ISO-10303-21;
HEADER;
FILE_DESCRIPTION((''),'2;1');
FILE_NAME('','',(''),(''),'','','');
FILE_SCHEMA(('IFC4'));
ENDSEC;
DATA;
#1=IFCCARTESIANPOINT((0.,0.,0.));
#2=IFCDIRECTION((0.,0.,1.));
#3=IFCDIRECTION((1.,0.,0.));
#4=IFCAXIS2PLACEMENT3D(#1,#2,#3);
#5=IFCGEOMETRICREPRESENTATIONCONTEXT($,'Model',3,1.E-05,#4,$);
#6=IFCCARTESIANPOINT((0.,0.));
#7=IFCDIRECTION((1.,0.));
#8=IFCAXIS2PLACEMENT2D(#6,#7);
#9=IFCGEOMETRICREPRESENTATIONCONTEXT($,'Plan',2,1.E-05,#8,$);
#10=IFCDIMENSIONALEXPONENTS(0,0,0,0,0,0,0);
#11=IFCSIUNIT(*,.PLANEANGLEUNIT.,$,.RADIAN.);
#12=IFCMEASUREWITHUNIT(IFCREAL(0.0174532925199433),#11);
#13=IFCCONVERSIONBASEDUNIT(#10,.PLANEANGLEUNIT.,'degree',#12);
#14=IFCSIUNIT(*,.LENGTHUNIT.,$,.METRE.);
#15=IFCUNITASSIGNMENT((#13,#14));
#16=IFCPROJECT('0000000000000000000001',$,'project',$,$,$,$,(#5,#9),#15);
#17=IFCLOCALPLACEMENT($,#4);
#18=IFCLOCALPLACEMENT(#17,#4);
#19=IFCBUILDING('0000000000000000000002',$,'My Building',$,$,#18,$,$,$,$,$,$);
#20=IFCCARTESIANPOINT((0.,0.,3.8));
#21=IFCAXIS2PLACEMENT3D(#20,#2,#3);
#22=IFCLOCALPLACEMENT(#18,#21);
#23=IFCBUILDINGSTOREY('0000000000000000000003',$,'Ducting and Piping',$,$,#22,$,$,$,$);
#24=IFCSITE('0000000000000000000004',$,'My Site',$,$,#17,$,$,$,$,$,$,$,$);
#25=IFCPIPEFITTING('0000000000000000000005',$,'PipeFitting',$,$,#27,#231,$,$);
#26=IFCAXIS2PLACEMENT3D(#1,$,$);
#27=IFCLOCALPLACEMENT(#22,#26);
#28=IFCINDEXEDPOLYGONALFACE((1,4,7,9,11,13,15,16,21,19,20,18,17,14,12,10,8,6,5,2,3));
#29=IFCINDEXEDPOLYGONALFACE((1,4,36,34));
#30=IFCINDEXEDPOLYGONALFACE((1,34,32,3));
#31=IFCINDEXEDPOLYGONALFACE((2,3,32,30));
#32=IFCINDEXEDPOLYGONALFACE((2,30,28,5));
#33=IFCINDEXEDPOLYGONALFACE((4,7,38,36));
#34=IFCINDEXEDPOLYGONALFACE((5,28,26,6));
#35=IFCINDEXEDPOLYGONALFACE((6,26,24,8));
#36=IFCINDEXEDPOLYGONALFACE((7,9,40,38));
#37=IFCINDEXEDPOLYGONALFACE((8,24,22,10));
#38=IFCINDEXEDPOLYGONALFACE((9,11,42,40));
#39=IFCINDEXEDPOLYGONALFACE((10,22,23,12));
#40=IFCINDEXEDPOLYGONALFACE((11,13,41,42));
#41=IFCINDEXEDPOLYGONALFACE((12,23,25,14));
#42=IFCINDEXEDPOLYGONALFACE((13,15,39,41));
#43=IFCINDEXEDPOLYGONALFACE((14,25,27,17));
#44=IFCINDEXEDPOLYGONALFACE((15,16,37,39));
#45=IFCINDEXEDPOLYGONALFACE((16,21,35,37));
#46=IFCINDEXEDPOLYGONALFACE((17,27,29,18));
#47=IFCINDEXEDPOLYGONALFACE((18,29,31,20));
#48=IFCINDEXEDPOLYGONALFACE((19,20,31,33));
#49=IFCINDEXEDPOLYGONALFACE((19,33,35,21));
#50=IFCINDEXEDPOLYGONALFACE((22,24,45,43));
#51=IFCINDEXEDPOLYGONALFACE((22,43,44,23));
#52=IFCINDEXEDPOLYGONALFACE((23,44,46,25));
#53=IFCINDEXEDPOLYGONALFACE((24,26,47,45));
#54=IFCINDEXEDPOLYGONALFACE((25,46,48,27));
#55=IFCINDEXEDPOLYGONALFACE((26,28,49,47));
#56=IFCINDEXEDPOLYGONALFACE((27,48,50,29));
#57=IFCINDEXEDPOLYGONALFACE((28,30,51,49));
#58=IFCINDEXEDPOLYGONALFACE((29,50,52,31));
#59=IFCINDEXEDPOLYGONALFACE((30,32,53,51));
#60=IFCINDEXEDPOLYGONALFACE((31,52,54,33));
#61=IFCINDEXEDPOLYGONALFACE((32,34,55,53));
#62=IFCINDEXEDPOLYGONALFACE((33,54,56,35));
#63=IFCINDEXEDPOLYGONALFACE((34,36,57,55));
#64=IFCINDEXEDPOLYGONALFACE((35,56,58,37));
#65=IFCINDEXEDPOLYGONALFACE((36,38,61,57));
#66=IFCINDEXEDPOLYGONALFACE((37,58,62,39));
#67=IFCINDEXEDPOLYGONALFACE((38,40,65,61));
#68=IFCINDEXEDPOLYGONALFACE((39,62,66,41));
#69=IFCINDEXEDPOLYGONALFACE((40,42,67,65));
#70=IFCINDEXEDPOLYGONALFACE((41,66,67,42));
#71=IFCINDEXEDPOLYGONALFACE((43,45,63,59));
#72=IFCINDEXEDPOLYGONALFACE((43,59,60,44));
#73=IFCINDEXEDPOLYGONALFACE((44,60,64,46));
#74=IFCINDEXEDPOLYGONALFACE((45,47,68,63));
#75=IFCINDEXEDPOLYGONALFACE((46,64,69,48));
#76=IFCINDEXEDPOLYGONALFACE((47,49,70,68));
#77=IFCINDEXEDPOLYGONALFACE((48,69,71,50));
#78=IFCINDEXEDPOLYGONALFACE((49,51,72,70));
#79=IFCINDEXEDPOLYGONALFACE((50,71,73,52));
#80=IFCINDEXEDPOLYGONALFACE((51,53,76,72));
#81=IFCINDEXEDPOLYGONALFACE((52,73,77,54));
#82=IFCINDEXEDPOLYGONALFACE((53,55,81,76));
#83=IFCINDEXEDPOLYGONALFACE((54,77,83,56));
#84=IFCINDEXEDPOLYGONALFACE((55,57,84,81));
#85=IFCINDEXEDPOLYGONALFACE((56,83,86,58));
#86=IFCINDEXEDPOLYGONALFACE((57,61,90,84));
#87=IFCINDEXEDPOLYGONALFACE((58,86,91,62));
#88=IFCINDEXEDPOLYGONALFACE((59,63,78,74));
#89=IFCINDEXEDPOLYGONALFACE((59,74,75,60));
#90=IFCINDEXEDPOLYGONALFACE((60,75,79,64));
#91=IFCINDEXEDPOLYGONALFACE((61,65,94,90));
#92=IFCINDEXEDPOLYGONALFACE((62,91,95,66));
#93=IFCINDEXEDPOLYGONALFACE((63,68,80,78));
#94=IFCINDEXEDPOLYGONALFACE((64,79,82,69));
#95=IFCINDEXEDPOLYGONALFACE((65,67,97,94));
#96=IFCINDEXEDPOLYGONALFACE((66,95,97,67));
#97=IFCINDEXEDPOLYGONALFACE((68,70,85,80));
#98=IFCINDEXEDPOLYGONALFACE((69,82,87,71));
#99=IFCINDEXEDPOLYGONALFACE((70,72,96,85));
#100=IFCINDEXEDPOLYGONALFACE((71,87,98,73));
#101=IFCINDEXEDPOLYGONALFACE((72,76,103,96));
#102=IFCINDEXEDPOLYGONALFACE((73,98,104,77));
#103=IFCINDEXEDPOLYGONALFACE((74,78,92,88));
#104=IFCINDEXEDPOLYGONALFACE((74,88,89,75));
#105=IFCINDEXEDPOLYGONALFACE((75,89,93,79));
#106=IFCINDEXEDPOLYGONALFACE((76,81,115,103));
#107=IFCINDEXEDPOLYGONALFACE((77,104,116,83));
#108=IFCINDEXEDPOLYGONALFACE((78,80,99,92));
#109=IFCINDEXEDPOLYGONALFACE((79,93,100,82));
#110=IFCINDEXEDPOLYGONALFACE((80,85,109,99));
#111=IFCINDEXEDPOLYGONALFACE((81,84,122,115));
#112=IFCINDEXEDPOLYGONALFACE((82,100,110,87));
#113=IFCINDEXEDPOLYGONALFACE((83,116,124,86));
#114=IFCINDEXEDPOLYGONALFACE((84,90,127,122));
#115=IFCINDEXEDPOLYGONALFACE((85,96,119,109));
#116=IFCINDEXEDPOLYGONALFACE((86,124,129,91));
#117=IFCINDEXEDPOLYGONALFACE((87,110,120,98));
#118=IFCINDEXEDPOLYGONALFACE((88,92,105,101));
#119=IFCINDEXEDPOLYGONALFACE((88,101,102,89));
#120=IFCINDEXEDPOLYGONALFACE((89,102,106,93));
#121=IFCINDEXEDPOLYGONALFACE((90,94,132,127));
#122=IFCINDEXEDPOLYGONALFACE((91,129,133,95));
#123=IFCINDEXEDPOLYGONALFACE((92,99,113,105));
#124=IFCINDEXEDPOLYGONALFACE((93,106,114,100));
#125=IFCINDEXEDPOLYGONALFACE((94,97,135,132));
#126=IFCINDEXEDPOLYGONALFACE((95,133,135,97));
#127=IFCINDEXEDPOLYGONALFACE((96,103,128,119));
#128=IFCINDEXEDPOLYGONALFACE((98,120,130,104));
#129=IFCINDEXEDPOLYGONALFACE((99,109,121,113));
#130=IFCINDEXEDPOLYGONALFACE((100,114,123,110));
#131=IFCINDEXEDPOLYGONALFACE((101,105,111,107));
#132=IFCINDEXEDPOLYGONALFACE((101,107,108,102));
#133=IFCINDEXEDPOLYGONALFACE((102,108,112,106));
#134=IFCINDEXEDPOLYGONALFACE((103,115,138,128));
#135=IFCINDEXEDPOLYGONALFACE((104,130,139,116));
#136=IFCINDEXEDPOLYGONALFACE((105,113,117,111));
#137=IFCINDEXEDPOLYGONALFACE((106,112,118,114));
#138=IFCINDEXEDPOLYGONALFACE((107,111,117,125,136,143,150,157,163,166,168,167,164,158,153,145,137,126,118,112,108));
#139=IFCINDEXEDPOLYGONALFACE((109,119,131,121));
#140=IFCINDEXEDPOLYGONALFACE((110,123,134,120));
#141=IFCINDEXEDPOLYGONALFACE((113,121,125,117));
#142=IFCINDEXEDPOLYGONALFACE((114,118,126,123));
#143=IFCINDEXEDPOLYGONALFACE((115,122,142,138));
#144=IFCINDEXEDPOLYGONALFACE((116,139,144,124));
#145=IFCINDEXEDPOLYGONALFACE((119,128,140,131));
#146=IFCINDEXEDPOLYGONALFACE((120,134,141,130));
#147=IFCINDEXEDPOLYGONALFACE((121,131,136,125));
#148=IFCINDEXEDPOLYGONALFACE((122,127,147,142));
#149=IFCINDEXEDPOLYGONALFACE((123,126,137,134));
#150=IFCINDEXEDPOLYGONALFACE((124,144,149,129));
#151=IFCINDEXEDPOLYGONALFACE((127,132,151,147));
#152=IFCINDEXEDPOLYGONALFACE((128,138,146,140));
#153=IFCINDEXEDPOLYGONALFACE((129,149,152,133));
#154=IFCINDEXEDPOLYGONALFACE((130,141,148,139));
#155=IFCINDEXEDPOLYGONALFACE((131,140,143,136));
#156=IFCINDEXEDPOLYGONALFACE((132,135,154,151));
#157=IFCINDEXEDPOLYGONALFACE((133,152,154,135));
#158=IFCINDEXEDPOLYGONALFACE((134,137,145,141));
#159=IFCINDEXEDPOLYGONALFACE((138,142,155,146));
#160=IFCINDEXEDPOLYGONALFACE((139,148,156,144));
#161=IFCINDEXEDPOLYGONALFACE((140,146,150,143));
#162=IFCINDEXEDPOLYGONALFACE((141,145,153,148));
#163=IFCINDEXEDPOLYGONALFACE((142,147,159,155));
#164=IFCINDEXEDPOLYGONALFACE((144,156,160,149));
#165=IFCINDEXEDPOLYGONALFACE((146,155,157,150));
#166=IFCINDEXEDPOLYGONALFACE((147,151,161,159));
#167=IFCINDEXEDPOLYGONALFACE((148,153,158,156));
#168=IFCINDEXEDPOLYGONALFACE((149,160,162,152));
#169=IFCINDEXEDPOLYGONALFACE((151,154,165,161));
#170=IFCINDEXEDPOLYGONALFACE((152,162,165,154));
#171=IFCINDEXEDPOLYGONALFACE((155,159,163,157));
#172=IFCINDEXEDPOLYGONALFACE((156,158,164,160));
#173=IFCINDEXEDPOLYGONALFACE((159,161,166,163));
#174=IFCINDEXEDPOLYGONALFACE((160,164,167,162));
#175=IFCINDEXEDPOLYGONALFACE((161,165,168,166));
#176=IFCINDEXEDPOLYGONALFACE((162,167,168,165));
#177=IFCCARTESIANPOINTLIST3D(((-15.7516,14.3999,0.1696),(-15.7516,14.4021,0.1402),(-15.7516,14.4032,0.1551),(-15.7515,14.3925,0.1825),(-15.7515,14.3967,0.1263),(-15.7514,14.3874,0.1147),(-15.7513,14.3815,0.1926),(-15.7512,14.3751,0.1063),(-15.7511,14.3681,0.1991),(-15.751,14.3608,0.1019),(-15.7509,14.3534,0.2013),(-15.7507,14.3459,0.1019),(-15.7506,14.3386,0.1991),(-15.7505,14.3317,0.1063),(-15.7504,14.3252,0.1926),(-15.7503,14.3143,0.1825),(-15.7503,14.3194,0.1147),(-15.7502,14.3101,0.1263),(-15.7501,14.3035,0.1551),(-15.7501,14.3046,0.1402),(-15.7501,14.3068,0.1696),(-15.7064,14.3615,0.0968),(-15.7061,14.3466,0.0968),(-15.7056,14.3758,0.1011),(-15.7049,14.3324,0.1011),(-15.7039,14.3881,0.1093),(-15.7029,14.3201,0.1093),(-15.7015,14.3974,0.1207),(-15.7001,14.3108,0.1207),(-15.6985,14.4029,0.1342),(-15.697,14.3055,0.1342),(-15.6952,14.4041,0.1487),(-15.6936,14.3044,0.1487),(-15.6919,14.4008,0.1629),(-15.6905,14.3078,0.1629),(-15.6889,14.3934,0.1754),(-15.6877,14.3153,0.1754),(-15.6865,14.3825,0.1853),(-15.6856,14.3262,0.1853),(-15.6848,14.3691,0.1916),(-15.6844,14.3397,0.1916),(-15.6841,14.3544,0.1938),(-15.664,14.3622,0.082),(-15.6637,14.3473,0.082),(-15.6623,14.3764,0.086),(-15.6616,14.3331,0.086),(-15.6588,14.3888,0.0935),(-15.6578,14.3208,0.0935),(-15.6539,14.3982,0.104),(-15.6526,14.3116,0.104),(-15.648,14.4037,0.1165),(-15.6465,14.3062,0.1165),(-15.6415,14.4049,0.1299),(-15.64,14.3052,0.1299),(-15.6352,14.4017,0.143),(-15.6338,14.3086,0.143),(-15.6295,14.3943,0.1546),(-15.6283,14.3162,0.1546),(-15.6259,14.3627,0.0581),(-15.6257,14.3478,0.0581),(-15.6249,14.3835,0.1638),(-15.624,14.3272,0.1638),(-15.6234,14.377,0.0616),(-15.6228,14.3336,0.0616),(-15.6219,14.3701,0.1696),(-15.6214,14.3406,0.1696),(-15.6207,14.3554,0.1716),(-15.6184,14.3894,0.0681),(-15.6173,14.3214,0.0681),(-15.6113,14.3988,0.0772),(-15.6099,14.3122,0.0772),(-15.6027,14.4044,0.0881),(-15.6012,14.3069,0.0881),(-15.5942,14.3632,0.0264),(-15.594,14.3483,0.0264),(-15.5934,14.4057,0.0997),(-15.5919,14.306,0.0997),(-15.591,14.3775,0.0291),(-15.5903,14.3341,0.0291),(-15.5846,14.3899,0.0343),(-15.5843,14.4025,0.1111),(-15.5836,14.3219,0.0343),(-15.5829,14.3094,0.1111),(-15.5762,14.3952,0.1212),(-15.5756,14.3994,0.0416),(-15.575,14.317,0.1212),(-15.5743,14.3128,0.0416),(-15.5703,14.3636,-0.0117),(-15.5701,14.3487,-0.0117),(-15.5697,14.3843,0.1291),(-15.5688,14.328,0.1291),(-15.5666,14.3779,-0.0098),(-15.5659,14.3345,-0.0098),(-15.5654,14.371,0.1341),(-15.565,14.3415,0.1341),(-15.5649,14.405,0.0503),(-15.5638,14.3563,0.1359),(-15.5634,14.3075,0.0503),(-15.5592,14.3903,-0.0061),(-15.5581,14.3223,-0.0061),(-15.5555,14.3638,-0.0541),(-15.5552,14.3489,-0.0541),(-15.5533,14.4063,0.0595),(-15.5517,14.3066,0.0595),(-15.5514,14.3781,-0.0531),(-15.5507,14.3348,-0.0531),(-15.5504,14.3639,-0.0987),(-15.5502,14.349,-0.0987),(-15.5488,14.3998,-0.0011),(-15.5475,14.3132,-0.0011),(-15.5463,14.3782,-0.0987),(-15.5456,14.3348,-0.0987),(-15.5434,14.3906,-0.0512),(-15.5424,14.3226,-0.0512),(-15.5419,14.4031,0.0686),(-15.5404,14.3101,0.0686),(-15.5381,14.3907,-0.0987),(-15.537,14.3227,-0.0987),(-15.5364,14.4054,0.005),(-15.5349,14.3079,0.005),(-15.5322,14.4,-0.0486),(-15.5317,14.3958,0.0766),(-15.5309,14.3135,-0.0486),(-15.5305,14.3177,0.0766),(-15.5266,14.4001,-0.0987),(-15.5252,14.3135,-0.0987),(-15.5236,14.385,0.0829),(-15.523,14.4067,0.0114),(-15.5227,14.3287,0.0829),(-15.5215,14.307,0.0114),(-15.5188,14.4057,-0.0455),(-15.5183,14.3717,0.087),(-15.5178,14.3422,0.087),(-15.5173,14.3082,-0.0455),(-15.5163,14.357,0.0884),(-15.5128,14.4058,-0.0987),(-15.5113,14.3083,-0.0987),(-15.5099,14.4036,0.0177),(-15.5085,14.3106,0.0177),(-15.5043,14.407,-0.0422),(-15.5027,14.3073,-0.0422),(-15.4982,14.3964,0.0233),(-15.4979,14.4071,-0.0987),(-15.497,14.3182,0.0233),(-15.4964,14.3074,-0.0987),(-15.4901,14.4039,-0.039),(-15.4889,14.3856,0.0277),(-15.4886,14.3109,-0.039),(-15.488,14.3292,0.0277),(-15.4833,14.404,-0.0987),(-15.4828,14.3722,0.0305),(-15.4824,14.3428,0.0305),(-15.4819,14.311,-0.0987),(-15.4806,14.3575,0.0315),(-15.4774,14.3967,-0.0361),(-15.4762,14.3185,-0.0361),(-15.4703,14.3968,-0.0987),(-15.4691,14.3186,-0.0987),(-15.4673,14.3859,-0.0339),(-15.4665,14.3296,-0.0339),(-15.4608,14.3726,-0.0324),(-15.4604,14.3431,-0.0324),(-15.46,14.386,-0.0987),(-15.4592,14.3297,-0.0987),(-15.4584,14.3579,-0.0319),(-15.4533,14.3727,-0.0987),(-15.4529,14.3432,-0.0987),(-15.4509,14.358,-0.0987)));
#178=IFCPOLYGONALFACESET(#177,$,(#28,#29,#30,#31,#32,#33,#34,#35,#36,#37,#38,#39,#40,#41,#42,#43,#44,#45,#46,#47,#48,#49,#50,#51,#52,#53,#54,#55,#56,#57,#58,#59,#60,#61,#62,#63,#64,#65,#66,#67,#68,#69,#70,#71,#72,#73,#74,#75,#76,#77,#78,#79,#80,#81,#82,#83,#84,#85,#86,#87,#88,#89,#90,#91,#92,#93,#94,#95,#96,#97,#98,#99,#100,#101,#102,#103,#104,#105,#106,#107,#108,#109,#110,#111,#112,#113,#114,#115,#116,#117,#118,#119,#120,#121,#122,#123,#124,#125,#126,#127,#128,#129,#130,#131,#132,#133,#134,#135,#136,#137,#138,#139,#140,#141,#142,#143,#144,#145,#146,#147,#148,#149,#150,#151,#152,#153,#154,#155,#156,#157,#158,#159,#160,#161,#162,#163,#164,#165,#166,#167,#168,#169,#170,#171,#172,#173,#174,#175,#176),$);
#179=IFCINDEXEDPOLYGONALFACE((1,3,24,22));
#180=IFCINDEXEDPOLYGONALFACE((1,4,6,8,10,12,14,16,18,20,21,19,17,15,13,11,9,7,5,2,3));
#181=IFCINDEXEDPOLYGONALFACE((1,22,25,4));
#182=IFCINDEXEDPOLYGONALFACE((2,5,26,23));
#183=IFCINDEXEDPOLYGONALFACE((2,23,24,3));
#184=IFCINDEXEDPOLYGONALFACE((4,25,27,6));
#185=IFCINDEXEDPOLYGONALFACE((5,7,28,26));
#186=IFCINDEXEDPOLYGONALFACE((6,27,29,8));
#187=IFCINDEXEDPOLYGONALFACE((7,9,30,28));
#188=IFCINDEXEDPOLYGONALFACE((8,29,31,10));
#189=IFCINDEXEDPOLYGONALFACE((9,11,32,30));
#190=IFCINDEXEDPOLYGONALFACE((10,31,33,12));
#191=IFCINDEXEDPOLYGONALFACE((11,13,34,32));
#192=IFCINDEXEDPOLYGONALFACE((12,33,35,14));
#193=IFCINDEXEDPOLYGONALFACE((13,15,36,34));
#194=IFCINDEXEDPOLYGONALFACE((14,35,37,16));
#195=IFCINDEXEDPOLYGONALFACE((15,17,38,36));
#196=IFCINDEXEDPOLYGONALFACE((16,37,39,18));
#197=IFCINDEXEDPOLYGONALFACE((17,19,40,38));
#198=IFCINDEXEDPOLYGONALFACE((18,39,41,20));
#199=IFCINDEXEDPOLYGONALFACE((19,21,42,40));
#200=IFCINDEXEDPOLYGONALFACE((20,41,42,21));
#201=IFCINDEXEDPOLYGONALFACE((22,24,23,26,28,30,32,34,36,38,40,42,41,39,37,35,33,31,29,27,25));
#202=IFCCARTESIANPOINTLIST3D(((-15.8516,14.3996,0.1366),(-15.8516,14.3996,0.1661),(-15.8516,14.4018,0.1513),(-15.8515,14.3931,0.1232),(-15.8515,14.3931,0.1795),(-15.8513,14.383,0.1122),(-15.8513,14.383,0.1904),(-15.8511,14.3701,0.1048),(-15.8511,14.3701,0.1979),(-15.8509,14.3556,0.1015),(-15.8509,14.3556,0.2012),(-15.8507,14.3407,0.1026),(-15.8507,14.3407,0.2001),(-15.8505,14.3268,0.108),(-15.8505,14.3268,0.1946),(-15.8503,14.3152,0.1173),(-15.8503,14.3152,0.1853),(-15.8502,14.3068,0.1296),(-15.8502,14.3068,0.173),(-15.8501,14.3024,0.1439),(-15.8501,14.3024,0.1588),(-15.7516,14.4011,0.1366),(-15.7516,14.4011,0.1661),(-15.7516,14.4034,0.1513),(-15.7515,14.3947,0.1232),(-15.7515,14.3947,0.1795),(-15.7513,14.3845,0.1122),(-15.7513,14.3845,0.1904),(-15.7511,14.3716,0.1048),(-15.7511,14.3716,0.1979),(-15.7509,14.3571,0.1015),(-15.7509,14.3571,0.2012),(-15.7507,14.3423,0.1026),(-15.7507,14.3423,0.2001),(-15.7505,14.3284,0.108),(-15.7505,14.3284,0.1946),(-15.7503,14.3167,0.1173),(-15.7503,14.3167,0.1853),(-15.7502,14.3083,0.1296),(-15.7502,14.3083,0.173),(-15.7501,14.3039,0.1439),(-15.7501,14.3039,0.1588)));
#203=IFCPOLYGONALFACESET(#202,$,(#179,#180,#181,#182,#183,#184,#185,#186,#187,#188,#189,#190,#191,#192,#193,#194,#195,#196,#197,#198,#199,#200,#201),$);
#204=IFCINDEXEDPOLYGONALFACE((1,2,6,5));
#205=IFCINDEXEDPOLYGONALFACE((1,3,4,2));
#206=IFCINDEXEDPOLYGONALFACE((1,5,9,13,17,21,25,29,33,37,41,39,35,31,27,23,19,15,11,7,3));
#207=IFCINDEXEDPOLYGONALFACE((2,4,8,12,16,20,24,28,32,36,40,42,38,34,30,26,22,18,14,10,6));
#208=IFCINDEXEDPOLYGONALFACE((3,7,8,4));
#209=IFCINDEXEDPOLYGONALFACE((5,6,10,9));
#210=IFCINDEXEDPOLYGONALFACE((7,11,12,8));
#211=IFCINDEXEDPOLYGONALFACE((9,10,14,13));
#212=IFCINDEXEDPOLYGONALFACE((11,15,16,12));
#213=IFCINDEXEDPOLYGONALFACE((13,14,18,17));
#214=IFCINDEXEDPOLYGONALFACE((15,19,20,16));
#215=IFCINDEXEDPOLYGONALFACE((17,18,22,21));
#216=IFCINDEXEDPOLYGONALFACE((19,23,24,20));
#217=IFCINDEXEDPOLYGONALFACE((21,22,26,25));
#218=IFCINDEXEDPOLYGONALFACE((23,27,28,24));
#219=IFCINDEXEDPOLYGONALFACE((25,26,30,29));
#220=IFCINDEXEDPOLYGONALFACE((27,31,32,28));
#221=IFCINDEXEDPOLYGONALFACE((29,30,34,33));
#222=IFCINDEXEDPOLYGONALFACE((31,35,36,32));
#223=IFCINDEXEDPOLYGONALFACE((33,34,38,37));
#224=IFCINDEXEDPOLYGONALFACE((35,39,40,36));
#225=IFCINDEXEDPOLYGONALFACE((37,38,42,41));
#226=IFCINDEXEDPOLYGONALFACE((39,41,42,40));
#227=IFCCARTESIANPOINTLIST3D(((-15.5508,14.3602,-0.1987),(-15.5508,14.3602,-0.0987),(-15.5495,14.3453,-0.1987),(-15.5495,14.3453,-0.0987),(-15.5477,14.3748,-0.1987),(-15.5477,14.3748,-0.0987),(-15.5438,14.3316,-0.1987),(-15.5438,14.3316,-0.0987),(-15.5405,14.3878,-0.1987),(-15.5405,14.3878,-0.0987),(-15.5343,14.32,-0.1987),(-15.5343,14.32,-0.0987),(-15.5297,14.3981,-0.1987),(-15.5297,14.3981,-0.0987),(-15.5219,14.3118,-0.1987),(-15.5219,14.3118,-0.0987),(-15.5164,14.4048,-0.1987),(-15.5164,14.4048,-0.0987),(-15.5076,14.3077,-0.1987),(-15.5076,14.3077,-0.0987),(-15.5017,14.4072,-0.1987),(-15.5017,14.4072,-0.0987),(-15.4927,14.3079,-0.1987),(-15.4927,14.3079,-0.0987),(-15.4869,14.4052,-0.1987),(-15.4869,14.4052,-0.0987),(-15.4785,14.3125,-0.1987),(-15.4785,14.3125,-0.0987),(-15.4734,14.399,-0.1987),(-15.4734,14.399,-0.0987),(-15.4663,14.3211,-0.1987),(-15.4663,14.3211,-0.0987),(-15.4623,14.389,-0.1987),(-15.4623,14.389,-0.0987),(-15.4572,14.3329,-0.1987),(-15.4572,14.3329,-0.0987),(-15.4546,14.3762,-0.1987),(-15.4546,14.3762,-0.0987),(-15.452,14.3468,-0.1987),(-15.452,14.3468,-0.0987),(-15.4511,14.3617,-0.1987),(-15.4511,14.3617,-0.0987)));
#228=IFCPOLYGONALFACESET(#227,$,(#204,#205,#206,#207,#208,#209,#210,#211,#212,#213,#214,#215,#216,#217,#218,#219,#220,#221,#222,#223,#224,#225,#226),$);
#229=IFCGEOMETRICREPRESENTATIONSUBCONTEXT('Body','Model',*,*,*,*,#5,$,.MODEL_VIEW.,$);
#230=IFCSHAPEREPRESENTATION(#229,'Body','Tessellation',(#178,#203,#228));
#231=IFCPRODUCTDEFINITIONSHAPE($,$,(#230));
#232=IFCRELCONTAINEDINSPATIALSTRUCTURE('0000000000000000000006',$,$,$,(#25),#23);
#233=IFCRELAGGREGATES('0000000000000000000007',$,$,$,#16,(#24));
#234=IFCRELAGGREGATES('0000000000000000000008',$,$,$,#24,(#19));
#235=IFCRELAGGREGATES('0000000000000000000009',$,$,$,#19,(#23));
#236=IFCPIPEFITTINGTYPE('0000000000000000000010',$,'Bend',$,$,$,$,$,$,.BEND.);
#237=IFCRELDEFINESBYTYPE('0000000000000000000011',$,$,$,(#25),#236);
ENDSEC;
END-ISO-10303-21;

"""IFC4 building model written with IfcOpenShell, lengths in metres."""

from ifc_helpers import new_model, entity, si_unit, converted_unit, frame, origin_with_axes, origin_2d_with_axis, place, context, subcontext, project, spatial, circle, extrude, source, transform, mapped, type_object, type_shapes, element, save


model = new_model("IFC4")

# Units and contexts
model_context = context("Model", 3, precision=1e-05, world=origin_with_axes())
plan_context = context("Plan", 2, precision=1e-05, world=origin_2d_with_axis())
body_context = subcontext(model_context, "Body", "Model", "MODEL_VIEW")
ifc_project = project(units=[converted_unit("PLANEANGLEUNIT", "degree", entity("IfcReal", 0.0174532925199433), si_unit("PLANEANGLEUNIT", "RADIAN"), dimensions=[0, 0, 0, 0, 0, 0, 0]), si_unit("LENGTHUNIT", "METRE")], contexts=[model_context, plan_context])

# Site, building, storey
site_placement = place(None, origin_with_axes())
site = spatial("IfcSite", under=ifc_project, at=site_placement, Name="My Site")
building_placement = place(site_placement, origin_with_axes())
building = spatial("IfcBuilding", under=site, at=building_placement, Name="My Building")
storey_placement = place(building_placement, frame((0.0, 0.0, 3.8), z_axis=(0.0, 0.0, 1.0), x_axis=(1.0, 0.0, 0.0)))
storey = spatial("IfcBuildingStorey", under=building, at=storey_placement, Name="Ducting and Piping")

# Pipe fitting
pipe_fitting_type = type_object("IfcPipeFittingType", Name="Bend", PredefinedType="BEND")
shared_shape = source(origin_with_axes(), body_context, "Body", "SolidModel", [
    entity("IfcSweptDiskSolid", entity("IfcIndexedPolyCurve", entity("IfcCartesianPointList3D", [[0.0, 0.0, 0.1], [0.0, -0.0732, 0.2768], [0.0, -0.25, 0.35]]), [entity("IfcArcIndex", [1, 2, 3])]), 0.05),
    extrude(circle(Radius=0.05), origin_with_axes(), (0.0, 0.0, 1.0), 0.1),
    extrude(circle(Radius=0.05), frame((0.0, -0.25, 0.35), z_axis=(0.0, -1.0, 0.0), x_axis=(1.0, 0.0, 0.0)), (0.0, 0.0, 1.0), 0.1),
])
type_shapes(pipe_fitting_type, [shared_shape])
for number, where, z_axis, x_axis, name in (
    (1, (-15.8508, 14.3518, 0.1513), (0.999882, 0.015371, 0.0), (-0.015371, 0.999882, 0.0), "PipeFitting"),
):
    element("IfcPipeFitting", number, at=place(storey_placement, frame(where, z_axis=z_axis, x_axis=x_axis)), inside=storey, type_object=pipe_fitting_type, Name=name, context=body_context, shape_type="MappedRepresentation", body=[
        mapped(shared_shape, transform((0.0, 0.0, 0.0), x_axis=(1.0, 0.0, 0.0), y_axis=(0.0, 1.0, 0.0), z_axis=(0.0, 0.0, 1.0), scale=1.0)),
    ])

save(model, "model.ifc")
